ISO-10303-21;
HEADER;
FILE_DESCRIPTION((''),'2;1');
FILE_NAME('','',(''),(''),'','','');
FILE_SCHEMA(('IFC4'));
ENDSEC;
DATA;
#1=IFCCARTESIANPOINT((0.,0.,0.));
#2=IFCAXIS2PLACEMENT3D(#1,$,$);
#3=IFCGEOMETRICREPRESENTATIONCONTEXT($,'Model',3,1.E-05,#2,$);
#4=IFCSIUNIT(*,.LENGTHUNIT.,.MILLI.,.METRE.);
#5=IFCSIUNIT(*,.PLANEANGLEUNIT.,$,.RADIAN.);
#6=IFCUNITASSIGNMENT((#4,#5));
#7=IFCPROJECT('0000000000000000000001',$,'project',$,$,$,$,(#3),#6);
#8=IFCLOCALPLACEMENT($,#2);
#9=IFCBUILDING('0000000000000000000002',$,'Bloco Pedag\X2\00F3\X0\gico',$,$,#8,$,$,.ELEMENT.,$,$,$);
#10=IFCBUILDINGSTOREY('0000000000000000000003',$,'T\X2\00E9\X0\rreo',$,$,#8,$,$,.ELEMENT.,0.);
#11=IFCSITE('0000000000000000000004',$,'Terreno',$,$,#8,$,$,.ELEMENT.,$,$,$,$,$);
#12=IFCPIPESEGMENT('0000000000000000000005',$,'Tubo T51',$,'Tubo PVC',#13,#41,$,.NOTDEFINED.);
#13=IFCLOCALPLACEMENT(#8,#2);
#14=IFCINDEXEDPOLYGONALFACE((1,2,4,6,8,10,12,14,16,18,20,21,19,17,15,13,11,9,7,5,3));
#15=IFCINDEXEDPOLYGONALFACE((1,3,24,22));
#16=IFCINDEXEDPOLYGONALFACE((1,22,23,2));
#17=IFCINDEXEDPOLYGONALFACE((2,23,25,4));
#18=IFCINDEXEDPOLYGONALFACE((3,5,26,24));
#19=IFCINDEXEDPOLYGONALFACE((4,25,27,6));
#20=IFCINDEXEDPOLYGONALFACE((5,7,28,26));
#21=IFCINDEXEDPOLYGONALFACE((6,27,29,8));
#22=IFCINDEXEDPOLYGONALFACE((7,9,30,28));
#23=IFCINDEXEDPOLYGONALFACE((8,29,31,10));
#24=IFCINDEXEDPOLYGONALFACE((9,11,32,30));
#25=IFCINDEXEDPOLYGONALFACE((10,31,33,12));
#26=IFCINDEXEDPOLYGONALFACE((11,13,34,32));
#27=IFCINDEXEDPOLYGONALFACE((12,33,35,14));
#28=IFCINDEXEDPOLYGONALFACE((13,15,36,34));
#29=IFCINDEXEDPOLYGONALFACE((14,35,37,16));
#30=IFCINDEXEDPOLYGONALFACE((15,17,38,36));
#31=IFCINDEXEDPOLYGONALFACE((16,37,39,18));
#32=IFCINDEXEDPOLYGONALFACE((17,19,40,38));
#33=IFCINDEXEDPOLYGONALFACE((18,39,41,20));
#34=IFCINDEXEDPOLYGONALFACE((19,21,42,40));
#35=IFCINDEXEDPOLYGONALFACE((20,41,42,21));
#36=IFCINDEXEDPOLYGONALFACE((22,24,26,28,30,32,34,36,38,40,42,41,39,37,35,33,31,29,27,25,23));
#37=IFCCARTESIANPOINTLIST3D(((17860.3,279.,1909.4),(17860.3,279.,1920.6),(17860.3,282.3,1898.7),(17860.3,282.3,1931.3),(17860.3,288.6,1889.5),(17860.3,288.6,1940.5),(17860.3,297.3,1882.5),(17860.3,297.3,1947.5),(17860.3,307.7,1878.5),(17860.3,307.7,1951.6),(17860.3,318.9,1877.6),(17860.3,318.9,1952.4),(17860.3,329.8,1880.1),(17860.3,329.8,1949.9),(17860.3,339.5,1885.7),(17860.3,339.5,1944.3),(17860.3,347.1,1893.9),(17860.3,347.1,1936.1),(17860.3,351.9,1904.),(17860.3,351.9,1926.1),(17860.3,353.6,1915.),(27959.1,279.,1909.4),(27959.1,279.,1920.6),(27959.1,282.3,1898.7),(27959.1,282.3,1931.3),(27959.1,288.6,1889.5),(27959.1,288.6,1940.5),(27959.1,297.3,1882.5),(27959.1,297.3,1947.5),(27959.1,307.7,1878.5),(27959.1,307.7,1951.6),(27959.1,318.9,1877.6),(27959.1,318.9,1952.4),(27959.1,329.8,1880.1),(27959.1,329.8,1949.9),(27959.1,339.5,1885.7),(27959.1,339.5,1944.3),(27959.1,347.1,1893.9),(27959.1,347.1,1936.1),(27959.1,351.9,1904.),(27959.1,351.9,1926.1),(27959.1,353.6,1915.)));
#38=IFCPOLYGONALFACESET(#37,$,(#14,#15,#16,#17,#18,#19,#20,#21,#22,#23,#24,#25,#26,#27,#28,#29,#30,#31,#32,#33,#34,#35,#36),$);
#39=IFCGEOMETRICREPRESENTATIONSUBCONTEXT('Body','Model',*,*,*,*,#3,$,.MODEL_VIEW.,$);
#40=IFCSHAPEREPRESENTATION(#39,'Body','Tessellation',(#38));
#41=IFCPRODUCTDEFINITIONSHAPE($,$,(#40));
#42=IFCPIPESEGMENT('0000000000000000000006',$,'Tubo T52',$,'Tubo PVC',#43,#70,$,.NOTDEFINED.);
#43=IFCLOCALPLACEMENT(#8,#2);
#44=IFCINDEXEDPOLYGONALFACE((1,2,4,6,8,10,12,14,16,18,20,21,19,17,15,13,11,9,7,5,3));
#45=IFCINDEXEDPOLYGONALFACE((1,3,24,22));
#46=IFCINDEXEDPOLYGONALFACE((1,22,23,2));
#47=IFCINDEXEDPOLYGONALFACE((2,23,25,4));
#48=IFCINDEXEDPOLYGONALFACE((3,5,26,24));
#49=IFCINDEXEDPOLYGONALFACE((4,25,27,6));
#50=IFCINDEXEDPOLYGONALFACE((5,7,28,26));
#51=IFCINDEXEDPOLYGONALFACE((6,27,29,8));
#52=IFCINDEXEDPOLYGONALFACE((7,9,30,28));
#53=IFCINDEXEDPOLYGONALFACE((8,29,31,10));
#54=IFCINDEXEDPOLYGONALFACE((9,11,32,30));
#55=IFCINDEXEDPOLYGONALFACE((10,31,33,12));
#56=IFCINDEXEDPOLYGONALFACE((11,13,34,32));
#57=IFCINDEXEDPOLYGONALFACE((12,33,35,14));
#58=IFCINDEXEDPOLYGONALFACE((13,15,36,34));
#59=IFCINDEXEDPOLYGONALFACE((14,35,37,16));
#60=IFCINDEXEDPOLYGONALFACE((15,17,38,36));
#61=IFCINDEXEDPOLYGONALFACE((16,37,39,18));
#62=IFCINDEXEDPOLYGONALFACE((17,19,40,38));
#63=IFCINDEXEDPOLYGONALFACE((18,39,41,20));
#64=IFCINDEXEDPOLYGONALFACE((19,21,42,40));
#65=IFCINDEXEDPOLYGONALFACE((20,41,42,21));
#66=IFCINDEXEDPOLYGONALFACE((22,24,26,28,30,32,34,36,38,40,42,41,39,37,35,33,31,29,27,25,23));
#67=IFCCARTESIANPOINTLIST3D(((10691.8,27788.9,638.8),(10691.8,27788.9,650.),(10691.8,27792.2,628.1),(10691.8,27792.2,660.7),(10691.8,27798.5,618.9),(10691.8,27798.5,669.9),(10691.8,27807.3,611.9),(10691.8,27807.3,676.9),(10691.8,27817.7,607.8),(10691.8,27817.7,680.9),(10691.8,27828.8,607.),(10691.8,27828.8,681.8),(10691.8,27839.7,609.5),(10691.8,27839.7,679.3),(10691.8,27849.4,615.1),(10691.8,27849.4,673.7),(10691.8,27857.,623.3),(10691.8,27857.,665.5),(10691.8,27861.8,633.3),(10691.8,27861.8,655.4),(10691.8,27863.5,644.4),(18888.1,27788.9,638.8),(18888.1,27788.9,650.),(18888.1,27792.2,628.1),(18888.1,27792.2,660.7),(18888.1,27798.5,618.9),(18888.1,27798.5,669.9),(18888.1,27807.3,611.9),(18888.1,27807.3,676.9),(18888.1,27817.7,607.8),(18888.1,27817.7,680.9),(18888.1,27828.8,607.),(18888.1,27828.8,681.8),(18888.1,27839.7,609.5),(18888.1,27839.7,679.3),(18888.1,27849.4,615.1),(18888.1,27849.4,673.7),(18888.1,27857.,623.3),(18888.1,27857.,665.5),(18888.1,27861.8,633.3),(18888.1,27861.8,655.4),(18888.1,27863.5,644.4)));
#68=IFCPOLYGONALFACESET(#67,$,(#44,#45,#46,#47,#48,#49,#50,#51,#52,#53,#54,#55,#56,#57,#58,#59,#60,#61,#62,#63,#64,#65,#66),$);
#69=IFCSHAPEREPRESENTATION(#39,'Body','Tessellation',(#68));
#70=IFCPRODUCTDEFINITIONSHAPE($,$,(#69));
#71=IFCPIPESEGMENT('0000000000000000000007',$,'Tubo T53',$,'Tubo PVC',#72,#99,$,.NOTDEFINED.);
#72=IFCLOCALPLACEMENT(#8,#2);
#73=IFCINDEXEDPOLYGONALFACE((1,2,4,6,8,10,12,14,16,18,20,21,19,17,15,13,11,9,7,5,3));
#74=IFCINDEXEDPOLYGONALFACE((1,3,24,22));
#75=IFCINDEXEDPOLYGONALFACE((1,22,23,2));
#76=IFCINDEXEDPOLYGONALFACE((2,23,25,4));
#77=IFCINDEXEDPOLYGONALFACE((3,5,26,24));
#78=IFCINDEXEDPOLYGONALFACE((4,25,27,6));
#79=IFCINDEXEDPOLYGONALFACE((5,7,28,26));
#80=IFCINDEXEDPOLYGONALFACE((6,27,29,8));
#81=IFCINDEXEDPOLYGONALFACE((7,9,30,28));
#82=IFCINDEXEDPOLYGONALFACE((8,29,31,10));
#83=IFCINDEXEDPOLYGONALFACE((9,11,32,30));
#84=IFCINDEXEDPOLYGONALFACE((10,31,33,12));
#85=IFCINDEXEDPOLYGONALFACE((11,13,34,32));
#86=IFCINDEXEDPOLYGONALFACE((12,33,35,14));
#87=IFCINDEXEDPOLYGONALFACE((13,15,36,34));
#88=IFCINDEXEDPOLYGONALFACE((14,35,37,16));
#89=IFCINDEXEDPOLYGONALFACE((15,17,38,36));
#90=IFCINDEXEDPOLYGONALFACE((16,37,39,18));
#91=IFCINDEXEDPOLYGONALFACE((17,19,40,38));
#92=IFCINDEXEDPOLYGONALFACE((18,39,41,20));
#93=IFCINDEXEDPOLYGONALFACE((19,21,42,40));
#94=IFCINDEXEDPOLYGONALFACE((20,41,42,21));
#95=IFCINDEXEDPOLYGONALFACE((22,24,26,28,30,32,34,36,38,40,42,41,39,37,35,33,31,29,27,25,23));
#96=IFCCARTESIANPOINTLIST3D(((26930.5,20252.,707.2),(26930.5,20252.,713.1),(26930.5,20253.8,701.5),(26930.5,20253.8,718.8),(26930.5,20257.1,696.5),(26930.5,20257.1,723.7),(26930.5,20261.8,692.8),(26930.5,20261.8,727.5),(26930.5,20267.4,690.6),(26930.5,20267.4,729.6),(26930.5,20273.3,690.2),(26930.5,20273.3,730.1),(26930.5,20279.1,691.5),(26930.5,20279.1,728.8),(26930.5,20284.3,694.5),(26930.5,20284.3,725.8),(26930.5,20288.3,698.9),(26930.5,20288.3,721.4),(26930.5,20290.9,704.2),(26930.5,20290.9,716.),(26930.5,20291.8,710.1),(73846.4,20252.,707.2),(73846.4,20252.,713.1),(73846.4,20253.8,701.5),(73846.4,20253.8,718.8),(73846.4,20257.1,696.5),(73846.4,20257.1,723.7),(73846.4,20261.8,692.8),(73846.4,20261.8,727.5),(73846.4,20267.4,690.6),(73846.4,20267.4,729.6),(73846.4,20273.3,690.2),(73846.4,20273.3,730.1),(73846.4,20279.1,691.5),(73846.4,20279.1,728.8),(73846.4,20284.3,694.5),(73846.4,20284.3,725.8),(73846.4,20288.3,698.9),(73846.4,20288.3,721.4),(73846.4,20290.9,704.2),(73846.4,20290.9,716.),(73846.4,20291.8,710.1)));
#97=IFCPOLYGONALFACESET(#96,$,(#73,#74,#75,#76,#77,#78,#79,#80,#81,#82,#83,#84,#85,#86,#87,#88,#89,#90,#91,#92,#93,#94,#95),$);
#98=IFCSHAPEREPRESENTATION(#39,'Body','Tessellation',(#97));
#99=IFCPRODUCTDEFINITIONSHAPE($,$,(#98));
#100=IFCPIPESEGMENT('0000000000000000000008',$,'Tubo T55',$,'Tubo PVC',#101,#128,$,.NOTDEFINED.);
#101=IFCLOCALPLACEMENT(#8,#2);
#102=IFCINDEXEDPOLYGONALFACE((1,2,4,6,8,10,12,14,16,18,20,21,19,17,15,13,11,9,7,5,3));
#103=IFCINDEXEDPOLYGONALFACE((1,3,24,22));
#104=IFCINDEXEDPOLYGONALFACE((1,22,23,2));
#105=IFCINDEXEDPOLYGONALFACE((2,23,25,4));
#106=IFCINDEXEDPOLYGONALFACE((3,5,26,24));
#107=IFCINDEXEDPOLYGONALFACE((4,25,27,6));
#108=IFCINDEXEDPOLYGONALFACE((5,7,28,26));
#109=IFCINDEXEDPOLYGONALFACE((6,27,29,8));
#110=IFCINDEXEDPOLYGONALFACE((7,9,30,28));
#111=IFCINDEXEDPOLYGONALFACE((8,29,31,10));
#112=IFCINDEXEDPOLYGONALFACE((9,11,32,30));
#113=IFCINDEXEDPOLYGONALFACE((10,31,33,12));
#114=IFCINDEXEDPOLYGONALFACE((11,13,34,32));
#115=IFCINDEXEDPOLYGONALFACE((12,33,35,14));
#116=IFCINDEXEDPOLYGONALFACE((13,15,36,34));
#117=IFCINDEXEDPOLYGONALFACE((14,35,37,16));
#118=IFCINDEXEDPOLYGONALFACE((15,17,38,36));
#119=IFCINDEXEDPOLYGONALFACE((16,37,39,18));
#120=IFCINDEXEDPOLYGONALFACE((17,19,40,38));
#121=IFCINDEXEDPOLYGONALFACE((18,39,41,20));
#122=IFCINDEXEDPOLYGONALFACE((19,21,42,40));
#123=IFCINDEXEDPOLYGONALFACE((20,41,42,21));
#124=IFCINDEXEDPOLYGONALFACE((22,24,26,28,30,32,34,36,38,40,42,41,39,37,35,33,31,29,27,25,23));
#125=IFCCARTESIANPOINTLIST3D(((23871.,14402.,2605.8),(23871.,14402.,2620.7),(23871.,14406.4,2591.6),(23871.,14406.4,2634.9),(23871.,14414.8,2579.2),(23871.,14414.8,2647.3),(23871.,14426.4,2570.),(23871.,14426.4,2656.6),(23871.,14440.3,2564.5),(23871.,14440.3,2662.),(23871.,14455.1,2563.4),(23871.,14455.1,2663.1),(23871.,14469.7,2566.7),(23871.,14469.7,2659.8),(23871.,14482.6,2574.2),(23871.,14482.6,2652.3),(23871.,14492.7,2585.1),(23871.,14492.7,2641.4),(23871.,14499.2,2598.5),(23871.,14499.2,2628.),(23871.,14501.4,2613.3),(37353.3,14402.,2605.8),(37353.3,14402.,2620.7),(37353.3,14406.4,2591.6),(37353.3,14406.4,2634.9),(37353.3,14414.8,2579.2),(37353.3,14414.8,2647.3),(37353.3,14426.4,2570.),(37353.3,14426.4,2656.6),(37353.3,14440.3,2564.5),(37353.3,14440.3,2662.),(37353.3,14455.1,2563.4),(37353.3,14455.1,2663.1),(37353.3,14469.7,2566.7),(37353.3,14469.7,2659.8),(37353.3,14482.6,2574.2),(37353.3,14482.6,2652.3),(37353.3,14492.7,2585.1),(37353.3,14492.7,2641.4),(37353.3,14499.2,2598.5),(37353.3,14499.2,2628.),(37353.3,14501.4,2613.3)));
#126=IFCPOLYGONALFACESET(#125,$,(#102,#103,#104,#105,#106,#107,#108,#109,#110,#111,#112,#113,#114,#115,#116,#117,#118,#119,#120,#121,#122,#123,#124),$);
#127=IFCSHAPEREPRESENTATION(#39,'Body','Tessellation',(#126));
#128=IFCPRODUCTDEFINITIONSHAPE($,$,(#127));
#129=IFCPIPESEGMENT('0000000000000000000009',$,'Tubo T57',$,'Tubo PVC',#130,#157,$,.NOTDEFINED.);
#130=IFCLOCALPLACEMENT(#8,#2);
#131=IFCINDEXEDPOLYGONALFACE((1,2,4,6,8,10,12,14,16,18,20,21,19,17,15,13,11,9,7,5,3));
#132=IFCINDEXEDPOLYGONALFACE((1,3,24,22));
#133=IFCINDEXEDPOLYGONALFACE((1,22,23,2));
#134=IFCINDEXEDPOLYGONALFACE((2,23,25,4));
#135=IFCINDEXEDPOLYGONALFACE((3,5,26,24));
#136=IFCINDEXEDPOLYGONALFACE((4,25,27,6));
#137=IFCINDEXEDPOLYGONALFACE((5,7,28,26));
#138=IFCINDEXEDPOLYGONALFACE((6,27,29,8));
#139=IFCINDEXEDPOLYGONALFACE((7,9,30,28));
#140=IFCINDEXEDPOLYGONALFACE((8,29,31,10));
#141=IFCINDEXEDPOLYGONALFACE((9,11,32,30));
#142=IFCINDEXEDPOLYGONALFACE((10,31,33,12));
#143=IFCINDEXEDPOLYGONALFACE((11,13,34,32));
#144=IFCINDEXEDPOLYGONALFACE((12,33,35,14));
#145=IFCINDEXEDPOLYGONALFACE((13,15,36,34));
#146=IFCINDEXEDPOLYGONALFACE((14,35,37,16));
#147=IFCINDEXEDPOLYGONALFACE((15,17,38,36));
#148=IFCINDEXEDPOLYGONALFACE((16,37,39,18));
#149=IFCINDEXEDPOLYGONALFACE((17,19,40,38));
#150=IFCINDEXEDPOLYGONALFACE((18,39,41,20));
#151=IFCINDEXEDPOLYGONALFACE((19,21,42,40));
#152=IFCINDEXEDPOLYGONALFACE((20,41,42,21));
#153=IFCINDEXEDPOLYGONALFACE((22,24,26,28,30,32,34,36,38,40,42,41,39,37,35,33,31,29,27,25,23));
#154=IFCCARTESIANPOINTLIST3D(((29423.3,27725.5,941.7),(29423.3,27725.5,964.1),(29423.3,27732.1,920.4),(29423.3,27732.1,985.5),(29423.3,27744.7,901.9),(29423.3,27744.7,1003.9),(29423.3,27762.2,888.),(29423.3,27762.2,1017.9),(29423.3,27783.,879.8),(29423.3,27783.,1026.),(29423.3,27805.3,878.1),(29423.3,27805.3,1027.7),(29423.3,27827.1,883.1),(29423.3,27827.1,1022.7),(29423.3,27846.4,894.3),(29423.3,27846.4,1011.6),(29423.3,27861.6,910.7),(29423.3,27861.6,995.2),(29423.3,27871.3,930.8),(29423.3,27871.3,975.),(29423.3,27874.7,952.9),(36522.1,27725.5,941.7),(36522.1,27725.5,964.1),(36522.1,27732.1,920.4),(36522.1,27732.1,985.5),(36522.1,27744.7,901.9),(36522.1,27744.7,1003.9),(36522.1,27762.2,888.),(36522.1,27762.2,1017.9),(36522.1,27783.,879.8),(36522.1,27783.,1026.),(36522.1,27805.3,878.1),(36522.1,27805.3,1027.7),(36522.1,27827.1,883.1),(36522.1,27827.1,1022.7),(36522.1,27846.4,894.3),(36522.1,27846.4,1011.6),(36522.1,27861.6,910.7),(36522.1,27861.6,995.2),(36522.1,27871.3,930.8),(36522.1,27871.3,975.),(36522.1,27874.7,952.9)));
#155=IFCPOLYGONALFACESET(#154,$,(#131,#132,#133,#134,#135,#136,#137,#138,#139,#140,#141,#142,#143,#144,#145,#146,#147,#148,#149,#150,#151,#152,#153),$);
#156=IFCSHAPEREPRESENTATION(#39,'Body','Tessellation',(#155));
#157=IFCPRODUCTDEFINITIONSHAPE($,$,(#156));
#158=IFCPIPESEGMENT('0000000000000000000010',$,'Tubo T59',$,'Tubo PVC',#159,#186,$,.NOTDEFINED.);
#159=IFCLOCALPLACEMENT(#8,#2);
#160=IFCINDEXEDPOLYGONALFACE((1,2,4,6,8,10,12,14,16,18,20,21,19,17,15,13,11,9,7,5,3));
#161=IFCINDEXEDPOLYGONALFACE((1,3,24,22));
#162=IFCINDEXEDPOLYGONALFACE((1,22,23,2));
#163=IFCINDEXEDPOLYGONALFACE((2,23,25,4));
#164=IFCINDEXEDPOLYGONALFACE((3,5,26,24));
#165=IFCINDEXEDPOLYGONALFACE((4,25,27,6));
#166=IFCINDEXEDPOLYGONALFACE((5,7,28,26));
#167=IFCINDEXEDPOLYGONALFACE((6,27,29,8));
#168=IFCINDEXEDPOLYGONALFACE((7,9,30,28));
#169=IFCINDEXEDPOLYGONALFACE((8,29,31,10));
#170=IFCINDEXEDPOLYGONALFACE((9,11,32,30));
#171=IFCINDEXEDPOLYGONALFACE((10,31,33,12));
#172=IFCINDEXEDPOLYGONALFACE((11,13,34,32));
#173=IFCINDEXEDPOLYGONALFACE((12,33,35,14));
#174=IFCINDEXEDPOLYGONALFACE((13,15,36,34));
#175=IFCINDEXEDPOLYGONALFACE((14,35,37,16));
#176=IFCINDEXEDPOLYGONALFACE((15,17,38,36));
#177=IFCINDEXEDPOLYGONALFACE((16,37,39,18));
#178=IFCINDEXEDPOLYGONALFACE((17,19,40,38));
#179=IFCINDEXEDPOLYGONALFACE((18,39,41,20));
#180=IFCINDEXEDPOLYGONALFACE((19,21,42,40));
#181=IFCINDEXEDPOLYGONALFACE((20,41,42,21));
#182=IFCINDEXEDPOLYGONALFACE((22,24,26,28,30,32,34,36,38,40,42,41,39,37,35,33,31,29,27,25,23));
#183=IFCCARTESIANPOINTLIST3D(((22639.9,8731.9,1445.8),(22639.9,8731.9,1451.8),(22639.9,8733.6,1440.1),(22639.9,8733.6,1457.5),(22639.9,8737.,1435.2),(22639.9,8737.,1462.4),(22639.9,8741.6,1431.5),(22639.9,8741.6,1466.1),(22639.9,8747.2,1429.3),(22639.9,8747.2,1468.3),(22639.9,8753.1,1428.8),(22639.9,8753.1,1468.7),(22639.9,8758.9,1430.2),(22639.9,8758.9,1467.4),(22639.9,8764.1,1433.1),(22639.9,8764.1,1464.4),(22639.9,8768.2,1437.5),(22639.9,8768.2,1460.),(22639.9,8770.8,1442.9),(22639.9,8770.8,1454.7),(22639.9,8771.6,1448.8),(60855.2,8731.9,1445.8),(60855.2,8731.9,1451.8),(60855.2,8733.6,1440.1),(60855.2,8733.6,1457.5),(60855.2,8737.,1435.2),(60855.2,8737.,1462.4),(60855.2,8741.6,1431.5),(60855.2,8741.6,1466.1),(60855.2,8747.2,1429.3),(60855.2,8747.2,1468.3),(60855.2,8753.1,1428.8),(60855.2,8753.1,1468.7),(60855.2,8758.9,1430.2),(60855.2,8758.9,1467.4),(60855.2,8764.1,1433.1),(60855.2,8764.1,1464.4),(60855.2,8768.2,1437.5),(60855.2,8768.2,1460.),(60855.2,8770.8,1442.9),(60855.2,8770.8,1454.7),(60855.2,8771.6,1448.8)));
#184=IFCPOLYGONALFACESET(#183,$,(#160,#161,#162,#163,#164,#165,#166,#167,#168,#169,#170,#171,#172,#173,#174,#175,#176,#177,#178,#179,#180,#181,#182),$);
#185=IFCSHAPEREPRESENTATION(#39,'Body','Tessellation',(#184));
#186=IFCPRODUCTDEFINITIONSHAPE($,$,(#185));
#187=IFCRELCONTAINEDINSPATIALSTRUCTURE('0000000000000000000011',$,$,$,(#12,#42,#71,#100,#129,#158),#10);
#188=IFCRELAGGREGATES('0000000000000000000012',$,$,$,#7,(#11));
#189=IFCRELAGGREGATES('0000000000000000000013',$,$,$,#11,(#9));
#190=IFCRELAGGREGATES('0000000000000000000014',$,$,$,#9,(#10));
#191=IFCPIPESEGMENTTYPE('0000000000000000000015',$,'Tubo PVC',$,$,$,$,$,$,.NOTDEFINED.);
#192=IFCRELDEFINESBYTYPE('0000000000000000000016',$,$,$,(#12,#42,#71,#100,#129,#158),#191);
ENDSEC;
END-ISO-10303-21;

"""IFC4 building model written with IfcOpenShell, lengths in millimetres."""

from ifc_helpers import new_model, si_unit, frame, origin, origin_2d, place, context, subcontext, project, spatial, circle, extrude, type_object, element, save


model = new_model("IFC4")

# Units and contexts
model_context = context("Model", 3, precision=1e-05, world=origin())
body_context = subcontext(model_context, "Body", "Model", "MODEL_VIEW")
ifc_project = project(units=[si_unit("LENGTHUNIT", "METRE", prefix="MILLI"), si_unit("PLANEANGLEUNIT", "RADIAN")], contexts=[model_context])

# Site, building, storey
placement = place(None, origin())
site = spatial("IfcSite", under=ifc_project, at=placement, Name="Terreno", CompositionType="ELEMENT")
building = spatial("IfcBuilding", under=site, at=placement, Name="Bloco Pedagógico", CompositionType="ELEMENT")
storey = spatial("IfcBuildingStorey", under=building, at=placement, Name="Térreo", CompositionType="ELEMENT", Elevation=0.0)

# Pipe segments
pipe_segment_type = type_object("IfcPipeSegmentType", Name="Tubo PVC", PredefinedType="NOTDEFINED")
pipe_segment_1_placement = place(None, frame((17860.3, 316.1, 1915.0), z_axis=(1.0, 0.0, 0.0), x_axis=(0.0, 1.0, 0.0)))
element("IfcPipeSegment", 1, at=pipe_segment_1_placement, inside=storey, type_object=pipe_segment_type, Name="Tubo T51", ObjectType="Tubo PVC", PredefinedType="NOTDEFINED", context=body_context, shape_type="SweptSolid", body=[
    extrude(circle(Radius=37.5, at=origin_2d()), None, (0.0, 0.0, 1.0), 10098.9),
])
pipe_segment_2_placement = place(None, frame((10691.8, 27826.0, 644.4), z_axis=(1.0, 0.0, 0.0), x_axis=(0.0, 1.0, 0.0)))
element("IfcPipeSegment", 2, at=pipe_segment_2_placement, inside=storey, type_object=pipe_segment_type, Name="Tubo T52", ObjectType="Tubo PVC", PredefinedType="NOTDEFINED", context=body_context, shape_type="SweptSolid", body=[
    extrude(circle(Radius=37.5, at=origin_2d()), None, (0.0, 0.0, 1.0), 8196.3),
])
pipe_segment_3_placement = place(None, frame((26930.5, 20271.8, 710.1), z_axis=(1.0, 0.0, 0.0), x_axis=(0.0, 1.0, 0.0)))
element("IfcPipeSegment", 3, at=pipe_segment_3_placement, inside=storey, type_object=pipe_segment_type, Name="Tubo T53", ObjectType="Tubo PVC", PredefinedType="NOTDEFINED", context=body_context, shape_type="SweptSolid", body=[
    extrude(circle(Radius=20.0, at=origin_2d()), None, (0.0, 0.0, 1.0), 46915.9),
])
pipe_segment_4_placement = place(None, frame((23871.0, 14451.4, 2613.3), z_axis=(1.0, 0.0, 0.0), x_axis=(0.0, 1.0, 0.0)))
element("IfcPipeSegment", 4, at=pipe_segment_4_placement, inside=storey, type_object=pipe_segment_type, Name="Tubo T55", ObjectType="Tubo PVC", PredefinedType="NOTDEFINED", context=body_context, shape_type="SweptSolid", body=[
    extrude(circle(Radius=50.0, at=origin_2d()), None, (0.0, 0.0, 1.0), 13482.3),
])
pipe_segment_5_placement = place(None, frame((29423.3, 27799.7, 952.9), z_axis=(1.0, 0.0, 0.0), x_axis=(0.0, 1.0, 0.0)))
element("IfcPipeSegment", 5, at=pipe_segment_5_placement, inside=storey, type_object=pipe_segment_type, Name="Tubo T57", ObjectType="Tubo PVC", PredefinedType="NOTDEFINED", context=body_context, shape_type="SweptSolid", body=[
    extrude(circle(Radius=75.0, at=origin_2d()), None, (0.0, 0.0, 1.0), 7098.7),
])
pipe_segment_6_placement = place(None, frame((22639.9, 8751.6, 1448.8), z_axis=(1.0, 0.0, 0.0), x_axis=(0.0, 1.0, 0.0)))
element("IfcPipeSegment", 6, at=pipe_segment_6_placement, inside=storey, type_object=pipe_segment_type, Name="Tubo T59", ObjectType="Tubo PVC", PredefinedType="NOTDEFINED", context=body_context, shape_type="SweptSolid", body=[
    extrude(circle(Radius=20.0, at=origin_2d()), None, (0.0, 0.0, 1.0), 38215.3),
])

save(model, "model.ifc")
